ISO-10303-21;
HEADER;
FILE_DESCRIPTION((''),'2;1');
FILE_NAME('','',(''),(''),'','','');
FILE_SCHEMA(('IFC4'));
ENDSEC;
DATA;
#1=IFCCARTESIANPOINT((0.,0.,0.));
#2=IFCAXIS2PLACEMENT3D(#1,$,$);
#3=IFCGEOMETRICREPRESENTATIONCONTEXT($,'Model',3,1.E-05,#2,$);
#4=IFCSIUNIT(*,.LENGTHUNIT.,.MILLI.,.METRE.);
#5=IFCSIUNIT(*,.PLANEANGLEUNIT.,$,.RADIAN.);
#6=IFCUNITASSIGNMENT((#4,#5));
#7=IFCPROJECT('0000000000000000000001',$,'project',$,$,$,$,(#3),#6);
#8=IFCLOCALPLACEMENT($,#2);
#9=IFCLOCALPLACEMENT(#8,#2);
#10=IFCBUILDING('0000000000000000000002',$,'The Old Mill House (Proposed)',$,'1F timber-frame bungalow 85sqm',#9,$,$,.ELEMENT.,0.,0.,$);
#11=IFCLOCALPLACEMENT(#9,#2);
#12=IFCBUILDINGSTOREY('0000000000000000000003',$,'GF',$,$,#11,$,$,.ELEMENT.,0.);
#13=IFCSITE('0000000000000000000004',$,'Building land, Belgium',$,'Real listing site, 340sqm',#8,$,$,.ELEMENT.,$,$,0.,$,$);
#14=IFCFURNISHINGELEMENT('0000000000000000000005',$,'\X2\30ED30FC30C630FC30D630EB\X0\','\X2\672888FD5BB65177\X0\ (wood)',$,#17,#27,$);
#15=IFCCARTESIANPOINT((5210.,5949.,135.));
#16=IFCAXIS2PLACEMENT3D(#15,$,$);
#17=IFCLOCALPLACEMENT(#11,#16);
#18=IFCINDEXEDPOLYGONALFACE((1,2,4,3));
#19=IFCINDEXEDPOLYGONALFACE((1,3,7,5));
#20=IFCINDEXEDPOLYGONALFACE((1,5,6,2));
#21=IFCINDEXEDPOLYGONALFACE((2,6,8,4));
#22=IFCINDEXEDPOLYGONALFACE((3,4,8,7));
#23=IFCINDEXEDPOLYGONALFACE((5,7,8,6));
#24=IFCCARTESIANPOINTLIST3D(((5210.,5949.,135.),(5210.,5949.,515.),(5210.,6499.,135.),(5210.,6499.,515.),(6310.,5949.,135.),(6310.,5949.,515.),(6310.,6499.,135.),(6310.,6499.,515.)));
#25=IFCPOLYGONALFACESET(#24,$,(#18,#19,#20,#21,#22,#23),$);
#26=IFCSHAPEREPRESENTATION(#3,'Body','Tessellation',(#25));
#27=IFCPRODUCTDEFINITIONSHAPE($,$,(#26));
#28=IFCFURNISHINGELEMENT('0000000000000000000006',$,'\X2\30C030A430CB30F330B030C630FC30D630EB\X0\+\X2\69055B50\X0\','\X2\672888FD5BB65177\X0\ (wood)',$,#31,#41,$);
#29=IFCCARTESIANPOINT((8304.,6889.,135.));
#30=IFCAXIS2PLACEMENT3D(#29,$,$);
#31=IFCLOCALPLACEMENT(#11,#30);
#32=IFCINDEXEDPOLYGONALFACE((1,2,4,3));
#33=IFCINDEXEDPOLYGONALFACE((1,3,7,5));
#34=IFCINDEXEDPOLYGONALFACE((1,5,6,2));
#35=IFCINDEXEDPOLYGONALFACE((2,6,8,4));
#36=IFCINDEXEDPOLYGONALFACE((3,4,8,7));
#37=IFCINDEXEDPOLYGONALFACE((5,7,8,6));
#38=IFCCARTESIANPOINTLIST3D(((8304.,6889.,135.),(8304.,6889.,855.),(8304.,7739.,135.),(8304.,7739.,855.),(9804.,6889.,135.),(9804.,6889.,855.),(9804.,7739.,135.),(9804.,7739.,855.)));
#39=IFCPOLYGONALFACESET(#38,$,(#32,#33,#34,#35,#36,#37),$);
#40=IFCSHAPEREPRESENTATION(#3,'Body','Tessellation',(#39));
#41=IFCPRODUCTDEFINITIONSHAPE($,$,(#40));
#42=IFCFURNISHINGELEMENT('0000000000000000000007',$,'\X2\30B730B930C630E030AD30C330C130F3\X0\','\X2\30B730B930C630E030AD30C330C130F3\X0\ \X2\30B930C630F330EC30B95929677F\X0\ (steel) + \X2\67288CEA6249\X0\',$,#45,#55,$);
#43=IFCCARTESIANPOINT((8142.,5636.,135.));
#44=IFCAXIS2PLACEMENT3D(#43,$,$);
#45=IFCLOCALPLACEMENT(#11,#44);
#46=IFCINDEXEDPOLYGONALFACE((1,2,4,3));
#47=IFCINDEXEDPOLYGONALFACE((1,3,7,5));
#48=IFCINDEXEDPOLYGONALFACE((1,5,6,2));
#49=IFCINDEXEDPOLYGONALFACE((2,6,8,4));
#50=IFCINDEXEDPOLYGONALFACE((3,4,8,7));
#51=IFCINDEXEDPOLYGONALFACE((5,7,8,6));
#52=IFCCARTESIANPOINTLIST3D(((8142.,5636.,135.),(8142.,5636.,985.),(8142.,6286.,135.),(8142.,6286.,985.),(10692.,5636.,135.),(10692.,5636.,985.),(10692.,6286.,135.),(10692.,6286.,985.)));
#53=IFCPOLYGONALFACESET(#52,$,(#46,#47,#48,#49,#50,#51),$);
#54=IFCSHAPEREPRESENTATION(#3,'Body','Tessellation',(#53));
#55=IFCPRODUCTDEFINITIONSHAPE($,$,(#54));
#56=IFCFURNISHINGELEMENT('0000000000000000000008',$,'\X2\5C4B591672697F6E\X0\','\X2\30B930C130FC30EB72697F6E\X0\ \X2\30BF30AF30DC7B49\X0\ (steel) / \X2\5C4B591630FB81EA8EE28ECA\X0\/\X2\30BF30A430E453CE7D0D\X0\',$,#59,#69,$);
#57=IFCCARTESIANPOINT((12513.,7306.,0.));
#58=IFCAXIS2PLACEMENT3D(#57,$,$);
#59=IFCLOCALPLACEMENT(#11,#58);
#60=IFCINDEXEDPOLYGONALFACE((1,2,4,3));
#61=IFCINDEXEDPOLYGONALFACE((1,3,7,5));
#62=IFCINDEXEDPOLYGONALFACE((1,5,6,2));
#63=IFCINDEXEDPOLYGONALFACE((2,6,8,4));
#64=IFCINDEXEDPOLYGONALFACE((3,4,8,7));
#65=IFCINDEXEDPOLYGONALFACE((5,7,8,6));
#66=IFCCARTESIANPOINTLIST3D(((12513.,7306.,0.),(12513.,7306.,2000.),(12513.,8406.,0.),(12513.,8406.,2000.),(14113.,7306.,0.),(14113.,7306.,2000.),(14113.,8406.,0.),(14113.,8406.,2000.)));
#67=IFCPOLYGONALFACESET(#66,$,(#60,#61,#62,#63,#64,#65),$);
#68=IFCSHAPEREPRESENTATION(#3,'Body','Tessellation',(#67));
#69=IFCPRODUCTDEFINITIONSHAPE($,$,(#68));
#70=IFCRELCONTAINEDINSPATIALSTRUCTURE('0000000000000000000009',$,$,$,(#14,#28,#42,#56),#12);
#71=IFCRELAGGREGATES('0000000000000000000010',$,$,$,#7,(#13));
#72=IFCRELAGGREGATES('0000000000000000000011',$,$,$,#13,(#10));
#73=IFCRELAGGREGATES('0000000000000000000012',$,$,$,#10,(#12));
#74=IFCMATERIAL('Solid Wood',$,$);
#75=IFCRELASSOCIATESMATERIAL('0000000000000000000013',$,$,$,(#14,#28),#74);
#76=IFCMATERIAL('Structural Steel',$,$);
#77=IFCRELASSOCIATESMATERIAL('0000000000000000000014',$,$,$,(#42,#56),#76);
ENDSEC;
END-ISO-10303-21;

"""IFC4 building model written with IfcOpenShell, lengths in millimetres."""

from ifc_helpers import new_model, si_unit, frame, frame_2d, origin, place, context, project, spatial, rectangle, extrude, material, element, save


model = new_model("IFC4")

# Units and contexts
model_context = context("Model", 3, precision=1e-05, world=origin())
ifc_project = project(units=[si_unit("LENGTHUNIT", "METRE", prefix="MILLI"), si_unit("PLANEANGLEUNIT", "RADIAN")], contexts=[model_context])

# Site, building, storey
site_placement = place(None, origin())
site = spatial("IfcSite", under=ifc_project, at=site_placement, Name="Building land, Belgium", ObjectType="Real listing site, 340sqm", CompositionType="ELEMENT", RefElevation=0.0)
building_placement = place(site_placement, origin())
building = spatial("IfcBuilding", under=site, at=building_placement, Name="The Old Mill House (Proposed)", ObjectType="1F timber-frame bungalow 85sqm", CompositionType="ELEMENT", ElevationOfRefHeight=0.0, ElevationOfTerrain=0.0)
storey_placement = place(building_placement, origin())
storey = spatial("IfcBuildingStorey", under=building, at=storey_placement, Name="GF", CompositionType="ELEMENT", Elevation=0.0)

# Shared definitions
ifc_material_1 = material(Name="Solid Wood")

# Shared definitions
ifc_material_2 = material(Name="Structural Steel")

# Furnishing elements
furnishing_1_placement = place(storey_placement, frame((5210.0, 5949.0, 135.0)))
element("IfcFurnishingElement", 1, at=furnishing_1_placement, inside=storey, material=ifc_material_1, Name="ローテーブル", Description="木製家具 (wood)", context=model_context, shape_type="SweptSolid", body=[
    extrude(rectangle(XDim=1100.0, YDim=550.0, at=frame_2d((550.0, 275.0))), frame((5210.0, 5949.0, 135.0)), (0.0, 0.0, 1.0), 380.0),
])
furnishing_2_placement = place(storey_placement, frame((8304.0, 6889.0, 135.0)))
element("IfcFurnishingElement", 2, at=furnishing_2_placement, inside=storey, material=ifc_material_1, Name="ダイニングテーブル+椅子", Description="木製家具 (wood)", context=model_context, shape_type="SweptSolid", body=[
    extrude(rectangle(XDim=1500.0, YDim=850.0, at=frame_2d((750.0, 425.0))), frame((8304.0, 6889.0, 135.0)), (0.0, 0.0, 1.0), 720.0),
])
furnishing_3_placement = place(storey_placement, frame((8142.0, 5636.0, 135.0)))
element("IfcFurnishingElement", 3, at=furnishing_3_placement, inside=storey, material=ifc_material_2, Name="システムキッチン", Description="システムキッチン ステンレス天板 (steel) + 木質扉", context=model_context, shape_type="SweptSolid", body=[
    extrude(rectangle(XDim=2550.0, YDim=650.0, at=frame_2d((1275.0, 325.0))), frame((8142.0, 5636.0, 135.0)), (0.0, 0.0, 1.0), 850.0),
])
furnishing_4_placement = place(storey_placement, frame((12513.0, 7306.0, 0.0)))
element("IfcFurnishingElement", 4, at=furnishing_4_placement, inside=storey, material=ifc_material_2, Name="屋外物置", Description="スチール物置 タクボ等 (steel) / 屋外・自転車/タイヤ収納", context=model_context, shape_type="SweptSolid", body=[
    extrude(rectangle(XDim=1600.0, YDim=1100.0, at=frame_2d((800.0, 550.0))), frame((12513.0, 7306.0, 0.0)), (0.0, 0.0, 1.0), 2000.0),
])

save(model, "model.ifc")
